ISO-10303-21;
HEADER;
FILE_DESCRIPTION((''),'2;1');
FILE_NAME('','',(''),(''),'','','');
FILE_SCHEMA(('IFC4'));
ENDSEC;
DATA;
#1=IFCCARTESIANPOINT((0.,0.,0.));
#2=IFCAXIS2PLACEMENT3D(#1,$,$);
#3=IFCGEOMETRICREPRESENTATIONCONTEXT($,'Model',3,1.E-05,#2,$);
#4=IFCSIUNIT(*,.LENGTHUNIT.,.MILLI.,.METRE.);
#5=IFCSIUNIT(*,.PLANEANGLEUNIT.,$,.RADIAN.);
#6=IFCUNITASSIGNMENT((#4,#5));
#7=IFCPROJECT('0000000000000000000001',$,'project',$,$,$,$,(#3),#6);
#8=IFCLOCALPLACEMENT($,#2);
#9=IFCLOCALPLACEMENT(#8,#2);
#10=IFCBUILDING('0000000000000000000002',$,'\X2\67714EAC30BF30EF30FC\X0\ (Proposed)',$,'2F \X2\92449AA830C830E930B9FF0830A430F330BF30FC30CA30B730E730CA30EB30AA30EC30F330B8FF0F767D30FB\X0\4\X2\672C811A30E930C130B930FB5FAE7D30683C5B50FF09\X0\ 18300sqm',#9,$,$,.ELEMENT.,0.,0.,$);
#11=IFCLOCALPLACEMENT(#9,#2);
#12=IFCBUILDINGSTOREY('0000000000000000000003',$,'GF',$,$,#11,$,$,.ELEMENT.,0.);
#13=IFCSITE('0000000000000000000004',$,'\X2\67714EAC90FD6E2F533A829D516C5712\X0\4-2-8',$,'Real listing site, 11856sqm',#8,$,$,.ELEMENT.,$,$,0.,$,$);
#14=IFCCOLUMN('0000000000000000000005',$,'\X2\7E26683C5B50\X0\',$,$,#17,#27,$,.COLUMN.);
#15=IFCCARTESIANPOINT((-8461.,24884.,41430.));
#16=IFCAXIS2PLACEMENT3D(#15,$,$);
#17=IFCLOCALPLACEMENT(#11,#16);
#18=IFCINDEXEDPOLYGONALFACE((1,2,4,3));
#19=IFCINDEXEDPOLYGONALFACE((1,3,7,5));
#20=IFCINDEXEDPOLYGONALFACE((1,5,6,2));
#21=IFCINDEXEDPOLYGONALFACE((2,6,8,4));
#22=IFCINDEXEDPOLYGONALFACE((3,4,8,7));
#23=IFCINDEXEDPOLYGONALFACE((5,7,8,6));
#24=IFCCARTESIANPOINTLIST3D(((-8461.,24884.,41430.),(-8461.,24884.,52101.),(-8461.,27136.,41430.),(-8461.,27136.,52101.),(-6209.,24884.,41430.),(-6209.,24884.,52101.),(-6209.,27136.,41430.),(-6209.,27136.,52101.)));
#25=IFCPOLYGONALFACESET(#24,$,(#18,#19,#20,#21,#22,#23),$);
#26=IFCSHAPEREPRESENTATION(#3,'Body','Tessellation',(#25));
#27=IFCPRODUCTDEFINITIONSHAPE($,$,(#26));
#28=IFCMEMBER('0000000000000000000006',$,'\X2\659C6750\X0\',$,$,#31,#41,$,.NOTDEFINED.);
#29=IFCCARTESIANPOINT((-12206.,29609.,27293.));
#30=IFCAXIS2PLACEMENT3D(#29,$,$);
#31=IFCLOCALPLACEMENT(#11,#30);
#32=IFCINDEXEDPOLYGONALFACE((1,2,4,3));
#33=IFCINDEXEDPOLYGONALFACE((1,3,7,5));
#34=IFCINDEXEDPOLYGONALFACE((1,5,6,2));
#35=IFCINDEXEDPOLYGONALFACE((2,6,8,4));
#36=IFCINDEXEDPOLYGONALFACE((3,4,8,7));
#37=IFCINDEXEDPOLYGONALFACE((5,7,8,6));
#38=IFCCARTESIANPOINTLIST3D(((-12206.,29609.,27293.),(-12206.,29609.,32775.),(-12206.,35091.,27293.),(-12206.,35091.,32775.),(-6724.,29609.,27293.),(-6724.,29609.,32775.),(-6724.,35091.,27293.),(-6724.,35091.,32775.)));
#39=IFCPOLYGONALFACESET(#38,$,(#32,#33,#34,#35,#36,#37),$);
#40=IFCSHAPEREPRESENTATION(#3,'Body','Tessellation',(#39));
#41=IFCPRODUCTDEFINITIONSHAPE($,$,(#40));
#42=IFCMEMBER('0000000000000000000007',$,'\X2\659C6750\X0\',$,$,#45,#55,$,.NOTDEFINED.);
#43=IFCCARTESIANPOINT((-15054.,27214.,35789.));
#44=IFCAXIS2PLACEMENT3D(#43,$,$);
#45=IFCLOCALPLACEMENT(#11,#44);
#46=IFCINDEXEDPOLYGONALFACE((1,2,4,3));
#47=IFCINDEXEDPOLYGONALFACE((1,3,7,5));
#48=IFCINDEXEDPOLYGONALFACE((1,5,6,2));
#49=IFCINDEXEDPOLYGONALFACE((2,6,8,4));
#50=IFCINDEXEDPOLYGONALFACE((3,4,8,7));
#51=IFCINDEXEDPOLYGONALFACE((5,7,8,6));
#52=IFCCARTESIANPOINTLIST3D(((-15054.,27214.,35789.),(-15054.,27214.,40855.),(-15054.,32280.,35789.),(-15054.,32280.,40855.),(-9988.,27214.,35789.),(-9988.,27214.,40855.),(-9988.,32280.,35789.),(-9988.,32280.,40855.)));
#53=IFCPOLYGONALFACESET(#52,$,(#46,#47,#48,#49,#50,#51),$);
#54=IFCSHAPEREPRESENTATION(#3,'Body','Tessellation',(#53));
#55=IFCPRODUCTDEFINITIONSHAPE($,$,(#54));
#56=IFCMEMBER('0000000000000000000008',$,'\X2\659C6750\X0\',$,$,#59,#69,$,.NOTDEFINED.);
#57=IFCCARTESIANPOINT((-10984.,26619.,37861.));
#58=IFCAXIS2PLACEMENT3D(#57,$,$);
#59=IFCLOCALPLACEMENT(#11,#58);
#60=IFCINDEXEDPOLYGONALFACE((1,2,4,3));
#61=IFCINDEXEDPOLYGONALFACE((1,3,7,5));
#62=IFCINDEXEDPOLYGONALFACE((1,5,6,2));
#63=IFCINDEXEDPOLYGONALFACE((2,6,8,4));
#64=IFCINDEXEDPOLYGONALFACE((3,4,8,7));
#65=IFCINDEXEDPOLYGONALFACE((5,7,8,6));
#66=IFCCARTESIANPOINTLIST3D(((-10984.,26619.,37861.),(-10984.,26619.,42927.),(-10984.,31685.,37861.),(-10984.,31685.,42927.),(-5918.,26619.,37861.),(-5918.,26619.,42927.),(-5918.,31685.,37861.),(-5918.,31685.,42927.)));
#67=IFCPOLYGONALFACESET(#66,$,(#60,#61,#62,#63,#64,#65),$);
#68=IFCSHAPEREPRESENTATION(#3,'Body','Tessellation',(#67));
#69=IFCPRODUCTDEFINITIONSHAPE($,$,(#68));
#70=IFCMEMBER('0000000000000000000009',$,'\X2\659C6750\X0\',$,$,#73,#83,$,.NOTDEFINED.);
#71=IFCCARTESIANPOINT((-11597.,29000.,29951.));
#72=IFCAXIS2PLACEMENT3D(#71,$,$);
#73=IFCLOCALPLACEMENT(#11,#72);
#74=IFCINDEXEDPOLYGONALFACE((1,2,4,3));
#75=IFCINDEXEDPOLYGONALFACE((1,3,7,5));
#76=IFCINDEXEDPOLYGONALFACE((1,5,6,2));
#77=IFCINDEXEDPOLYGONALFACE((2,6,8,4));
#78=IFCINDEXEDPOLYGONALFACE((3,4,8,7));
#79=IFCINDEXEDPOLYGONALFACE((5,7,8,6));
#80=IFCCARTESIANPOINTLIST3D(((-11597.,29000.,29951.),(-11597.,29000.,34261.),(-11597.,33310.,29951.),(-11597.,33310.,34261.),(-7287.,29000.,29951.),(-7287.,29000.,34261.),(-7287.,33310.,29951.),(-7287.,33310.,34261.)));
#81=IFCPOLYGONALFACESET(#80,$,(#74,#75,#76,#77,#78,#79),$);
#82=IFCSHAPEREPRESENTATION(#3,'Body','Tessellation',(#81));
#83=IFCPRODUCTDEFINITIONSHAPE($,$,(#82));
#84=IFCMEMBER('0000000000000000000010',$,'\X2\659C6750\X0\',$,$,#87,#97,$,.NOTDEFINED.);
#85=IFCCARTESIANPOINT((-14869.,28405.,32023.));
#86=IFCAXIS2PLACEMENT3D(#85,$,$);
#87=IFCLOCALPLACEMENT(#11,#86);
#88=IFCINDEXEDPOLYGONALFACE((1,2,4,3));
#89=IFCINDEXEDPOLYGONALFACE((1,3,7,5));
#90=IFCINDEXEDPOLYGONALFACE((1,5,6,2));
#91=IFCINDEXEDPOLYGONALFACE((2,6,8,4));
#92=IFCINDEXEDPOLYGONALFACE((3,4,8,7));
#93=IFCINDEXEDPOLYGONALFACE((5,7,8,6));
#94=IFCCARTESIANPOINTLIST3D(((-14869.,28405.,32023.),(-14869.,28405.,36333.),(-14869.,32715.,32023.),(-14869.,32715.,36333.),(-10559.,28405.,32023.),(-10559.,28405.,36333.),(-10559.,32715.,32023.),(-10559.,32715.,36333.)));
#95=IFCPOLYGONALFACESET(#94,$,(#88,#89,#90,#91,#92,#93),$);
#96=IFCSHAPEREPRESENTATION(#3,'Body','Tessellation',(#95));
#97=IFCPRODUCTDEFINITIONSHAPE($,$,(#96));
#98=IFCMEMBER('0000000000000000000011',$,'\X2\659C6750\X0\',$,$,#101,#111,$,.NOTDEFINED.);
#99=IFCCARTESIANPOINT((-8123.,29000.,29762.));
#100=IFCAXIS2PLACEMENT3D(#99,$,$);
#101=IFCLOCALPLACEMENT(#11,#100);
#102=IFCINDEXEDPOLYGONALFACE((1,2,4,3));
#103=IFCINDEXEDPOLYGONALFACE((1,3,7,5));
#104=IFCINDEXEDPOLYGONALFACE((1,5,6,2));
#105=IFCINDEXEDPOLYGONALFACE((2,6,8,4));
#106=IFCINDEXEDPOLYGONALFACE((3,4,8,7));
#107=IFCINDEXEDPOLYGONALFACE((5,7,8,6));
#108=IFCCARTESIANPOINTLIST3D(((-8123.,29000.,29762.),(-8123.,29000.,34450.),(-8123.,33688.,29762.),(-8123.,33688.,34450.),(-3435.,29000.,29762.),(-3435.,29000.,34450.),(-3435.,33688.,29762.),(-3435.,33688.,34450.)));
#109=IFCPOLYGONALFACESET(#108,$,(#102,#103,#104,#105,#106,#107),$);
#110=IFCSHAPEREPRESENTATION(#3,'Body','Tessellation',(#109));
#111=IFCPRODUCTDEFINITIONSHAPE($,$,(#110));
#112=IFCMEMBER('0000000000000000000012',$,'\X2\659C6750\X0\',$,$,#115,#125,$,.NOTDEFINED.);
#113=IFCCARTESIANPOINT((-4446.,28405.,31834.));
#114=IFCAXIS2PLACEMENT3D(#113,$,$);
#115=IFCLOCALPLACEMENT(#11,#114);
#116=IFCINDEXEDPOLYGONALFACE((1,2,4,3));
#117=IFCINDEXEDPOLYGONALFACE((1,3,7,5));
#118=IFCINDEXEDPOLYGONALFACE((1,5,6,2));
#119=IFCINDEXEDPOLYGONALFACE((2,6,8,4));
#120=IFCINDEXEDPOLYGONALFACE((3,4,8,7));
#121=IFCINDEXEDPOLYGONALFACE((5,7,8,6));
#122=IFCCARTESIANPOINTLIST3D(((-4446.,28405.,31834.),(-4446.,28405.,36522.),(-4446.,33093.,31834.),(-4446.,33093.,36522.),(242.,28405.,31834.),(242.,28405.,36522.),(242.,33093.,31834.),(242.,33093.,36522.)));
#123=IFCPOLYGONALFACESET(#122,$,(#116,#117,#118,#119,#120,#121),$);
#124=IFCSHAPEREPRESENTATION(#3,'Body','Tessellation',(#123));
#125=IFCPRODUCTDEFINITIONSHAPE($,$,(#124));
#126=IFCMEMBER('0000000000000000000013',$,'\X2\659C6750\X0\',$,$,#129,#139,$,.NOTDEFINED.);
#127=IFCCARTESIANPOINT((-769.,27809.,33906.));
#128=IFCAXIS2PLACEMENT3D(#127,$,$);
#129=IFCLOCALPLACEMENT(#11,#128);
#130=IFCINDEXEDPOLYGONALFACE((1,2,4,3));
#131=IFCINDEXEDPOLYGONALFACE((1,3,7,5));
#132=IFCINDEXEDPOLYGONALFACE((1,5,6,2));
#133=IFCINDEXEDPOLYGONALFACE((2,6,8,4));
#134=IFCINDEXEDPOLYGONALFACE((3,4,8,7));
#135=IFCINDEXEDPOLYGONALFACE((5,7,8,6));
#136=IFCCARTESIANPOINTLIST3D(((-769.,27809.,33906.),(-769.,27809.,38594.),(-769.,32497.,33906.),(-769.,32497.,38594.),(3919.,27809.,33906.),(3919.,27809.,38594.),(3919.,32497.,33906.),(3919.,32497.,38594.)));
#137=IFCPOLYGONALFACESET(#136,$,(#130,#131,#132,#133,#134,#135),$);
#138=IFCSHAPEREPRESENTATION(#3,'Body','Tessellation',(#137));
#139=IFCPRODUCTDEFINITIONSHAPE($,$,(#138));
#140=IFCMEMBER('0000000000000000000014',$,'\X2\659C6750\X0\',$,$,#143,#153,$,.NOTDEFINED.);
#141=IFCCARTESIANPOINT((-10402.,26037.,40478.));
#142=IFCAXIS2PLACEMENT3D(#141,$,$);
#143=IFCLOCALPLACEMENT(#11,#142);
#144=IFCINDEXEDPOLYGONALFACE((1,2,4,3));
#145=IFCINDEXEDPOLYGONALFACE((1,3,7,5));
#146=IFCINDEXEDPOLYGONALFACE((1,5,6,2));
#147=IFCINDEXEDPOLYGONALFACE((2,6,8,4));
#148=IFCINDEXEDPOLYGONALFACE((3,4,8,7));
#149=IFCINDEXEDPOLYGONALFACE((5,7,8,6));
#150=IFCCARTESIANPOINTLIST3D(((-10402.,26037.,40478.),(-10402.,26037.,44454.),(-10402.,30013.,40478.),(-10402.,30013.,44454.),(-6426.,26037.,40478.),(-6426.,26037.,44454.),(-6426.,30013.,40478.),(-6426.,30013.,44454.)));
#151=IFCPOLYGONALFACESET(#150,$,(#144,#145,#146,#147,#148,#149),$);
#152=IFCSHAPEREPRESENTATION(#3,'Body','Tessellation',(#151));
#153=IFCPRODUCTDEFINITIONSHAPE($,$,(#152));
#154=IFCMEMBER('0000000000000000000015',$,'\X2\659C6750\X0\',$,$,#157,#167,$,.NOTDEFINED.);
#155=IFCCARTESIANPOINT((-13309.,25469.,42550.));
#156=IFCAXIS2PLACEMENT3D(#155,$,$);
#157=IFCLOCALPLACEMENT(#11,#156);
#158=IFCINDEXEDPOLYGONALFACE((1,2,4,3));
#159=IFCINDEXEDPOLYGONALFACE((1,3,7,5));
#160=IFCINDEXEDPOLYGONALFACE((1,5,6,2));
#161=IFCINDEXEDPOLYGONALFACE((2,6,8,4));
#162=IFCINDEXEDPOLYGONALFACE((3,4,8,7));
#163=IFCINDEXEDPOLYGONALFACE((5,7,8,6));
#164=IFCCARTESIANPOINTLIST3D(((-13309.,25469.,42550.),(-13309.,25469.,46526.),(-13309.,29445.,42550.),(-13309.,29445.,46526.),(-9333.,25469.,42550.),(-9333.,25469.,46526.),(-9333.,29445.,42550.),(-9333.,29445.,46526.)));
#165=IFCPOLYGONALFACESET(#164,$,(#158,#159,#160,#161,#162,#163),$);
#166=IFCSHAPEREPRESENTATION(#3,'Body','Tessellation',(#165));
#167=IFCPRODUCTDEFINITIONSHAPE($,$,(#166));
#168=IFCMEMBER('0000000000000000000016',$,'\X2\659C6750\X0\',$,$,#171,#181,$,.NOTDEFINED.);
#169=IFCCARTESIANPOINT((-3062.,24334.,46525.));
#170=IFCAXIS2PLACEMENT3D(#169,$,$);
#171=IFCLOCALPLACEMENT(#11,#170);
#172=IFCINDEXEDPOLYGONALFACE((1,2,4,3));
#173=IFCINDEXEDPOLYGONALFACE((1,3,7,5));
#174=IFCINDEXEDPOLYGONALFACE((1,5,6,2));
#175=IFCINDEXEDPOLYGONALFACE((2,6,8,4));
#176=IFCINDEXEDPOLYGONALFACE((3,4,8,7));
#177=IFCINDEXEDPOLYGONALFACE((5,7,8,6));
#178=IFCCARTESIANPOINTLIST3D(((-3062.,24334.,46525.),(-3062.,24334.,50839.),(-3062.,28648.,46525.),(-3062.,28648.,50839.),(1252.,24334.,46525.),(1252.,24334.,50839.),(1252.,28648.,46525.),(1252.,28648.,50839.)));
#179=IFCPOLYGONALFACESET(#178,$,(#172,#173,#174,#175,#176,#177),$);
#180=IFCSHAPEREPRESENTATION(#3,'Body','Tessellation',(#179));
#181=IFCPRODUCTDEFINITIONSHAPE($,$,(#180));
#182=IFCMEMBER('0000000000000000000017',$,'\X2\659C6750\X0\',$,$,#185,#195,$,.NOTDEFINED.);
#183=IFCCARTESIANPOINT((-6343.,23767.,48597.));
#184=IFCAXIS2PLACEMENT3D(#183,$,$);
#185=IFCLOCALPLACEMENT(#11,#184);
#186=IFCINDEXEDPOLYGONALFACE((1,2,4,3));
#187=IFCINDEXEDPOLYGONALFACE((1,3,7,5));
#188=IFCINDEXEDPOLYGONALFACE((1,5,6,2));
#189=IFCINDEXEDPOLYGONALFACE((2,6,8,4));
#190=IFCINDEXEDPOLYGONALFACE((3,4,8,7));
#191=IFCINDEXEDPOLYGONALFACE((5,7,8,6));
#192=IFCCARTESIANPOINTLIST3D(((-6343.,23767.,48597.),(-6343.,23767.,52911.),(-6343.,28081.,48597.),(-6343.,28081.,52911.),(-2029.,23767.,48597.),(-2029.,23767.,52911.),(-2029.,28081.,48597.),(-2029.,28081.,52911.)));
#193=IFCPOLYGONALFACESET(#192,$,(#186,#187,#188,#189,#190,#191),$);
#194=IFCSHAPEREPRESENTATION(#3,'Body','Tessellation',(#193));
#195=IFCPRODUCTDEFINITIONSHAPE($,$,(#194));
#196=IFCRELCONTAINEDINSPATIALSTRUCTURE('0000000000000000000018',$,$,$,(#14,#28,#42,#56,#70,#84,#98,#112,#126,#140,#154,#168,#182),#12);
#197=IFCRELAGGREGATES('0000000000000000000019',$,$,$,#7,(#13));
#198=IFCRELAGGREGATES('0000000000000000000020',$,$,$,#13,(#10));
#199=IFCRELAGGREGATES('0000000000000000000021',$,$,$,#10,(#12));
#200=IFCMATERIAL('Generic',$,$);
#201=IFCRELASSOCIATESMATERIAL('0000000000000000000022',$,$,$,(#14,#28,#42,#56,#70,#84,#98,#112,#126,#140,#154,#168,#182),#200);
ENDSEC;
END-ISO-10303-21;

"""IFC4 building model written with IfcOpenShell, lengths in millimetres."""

from ifc_helpers import new_model, si_unit, frame, frame_2d, origin, place, context, project, spatial, rectangle, extrude, material, element, save


model = new_model("IFC4")

# Units and contexts
model_context = context("Model", 3, precision=1e-05, world=origin())
ifc_project = project(units=[si_unit("LENGTHUNIT", "METRE", prefix="MILLI"), si_unit("PLANEANGLEUNIT", "RADIAN")], contexts=[model_context])

# Site, building, storey
site_placement = place(None, origin())
site = spatial("IfcSite", under=ifc_project, at=site_placement, Name="東京都港区芝公園4-2-8", ObjectType="Real listing site, 11856sqm", CompositionType="ELEMENT", RefElevation=0.0)
building_placement = place(site_placement, origin())
building = spatial("IfcBuilding", under=site, at=building_placement, Name="東京タワー (Proposed)", ObjectType="2F 鉄骨トラス（インターナショナルオレンジ／白・4本脚ラチス・微細格子） 18300sqm", CompositionType="ELEMENT", ElevationOfRefHeight=0.0, ElevationOfTerrain=0.0)
storey_placement = place(building_placement, origin())
storey = spatial("IfcBuildingStorey", under=building, at=storey_placement, Name="GF", CompositionType="ELEMENT", Elevation=0.0)

# Column
ifc_material = material(Name="Generic")
column_1_placement = place(storey_placement, frame((-8461.0, 24884.0, 41430.0)))
element("IfcColumn", 1, at=column_1_placement, inside=storey, material=ifc_material, Name="縦格子", PredefinedType="COLUMN", context=model_context, shape_type="SweptSolid", body=[
    extrude(rectangle(XDim=2252.0, YDim=2252.0, at=frame_2d((1126.0, 1126.0))), frame((-8461.0, 24884.0, 41430.0)), (0.0, 0.0, 1.0), 10671.0),
])

# Members
member_1_placement = place(storey_placement, frame((-12206.0, 29609.0, 27293.0)))
element("IfcMember", 2, at=member_1_placement, inside=storey, material=ifc_material, Name="斜材", PredefinedType="NOTDEFINED", context=model_context, shape_type="SweptSolid", body=[
    extrude(rectangle(XDim=5482.0, YDim=5482.0, at=frame_2d((2741.0, 2741.0))), frame((-12206.0, 29609.0, 27293.0)), (0.0, 0.0, 1.0), 5482.0),
])
member_2_placement = place(storey_placement, frame((-15054.0, 27214.0, 35789.0)))
element("IfcMember", 3, at=member_2_placement, inside=storey, material=ifc_material, Name="斜材", PredefinedType="NOTDEFINED", context=model_context, shape_type="SweptSolid", body=[
    extrude(rectangle(XDim=5066.0, YDim=5066.0, at=frame_2d((2533.0, 2533.0))), frame((-15054.0, 27214.0, 35789.0)), (0.0, 0.0, 1.0), 5066.0),
])
member_3_placement = place(storey_placement, frame((-10984.0, 26619.0, 37861.0)))
element("IfcMember", 4, at=member_3_placement, inside=storey, material=ifc_material, Name="斜材", PredefinedType="NOTDEFINED", context=model_context, shape_type="SweptSolid", body=[
    extrude(rectangle(XDim=5066.0, YDim=5066.0, at=frame_2d((2533.0, 2533.0))), frame((-10984.0, 26619.0, 37861.0)), (0.0, 0.0, 1.0), 5066.0),
])
member_4_placement = place(storey_placement, frame((-11597.0, 29000.0, 29951.0)))
element("IfcMember", 5, at=member_4_placement, inside=storey, material=ifc_material, Name="斜材", PredefinedType="NOTDEFINED", context=model_context, shape_type="SweptSolid", body=[
    extrude(rectangle(XDim=4310.0, YDim=4310.0, at=frame_2d((2155.0, 2155.0))), frame((-11597.0, 29000.0, 29951.0)), (0.0, 0.0, 1.0), 4310.0),
])
member_5_placement = place(storey_placement, frame((-14869.0, 28405.0, 32023.0)))
element("IfcMember", 6, at=member_5_placement, inside=storey, material=ifc_material, Name="斜材", PredefinedType="NOTDEFINED", context=model_context, shape_type="SweptSolid", body=[
    extrude(rectangle(XDim=4310.0, YDim=4310.0, at=frame_2d((2155.0, 2155.0))), frame((-14869.0, 28405.0, 32023.0)), (0.0, 0.0, 1.0), 4310.0),
])
member_6_placement = place(storey_placement, frame((-8123.0, 29000.0, 29762.0)))
element("IfcMember", 7, at=member_6_placement, inside=storey, material=ifc_material, Name="斜材", PredefinedType="NOTDEFINED", context=model_context, shape_type="SweptSolid", body=[
    extrude(rectangle(XDim=4688.0, YDim=4688.0, at=frame_2d((2344.0, 2344.0))), frame((-8123.0, 29000.0, 29762.0)), (0.0, 0.0, 1.0), 4688.0),
])
member_7_placement = place(storey_placement, frame((-4446.0, 28405.0, 31834.0)))
element("IfcMember", 8, at=member_7_placement, inside=storey, material=ifc_material, Name="斜材", PredefinedType="NOTDEFINED", context=model_context, shape_type="SweptSolid", body=[
    extrude(rectangle(XDim=4688.0, YDim=4688.0, at=frame_2d((2344.0, 2344.0))), frame((-4446.0, 28405.0, 31834.0)), (0.0, 0.0, 1.0), 4688.0),
])
member_8_placement = place(storey_placement, frame((-769.0, 27809.0, 33906.0)))
element("IfcMember", 9, at=member_8_placement, inside=storey, material=ifc_material, Name="斜材", PredefinedType="NOTDEFINED", context=model_context, shape_type="SweptSolid", body=[
    extrude(rectangle(XDim=4688.0, YDim=4688.0, at=frame_2d((2344.0, 2344.0))), frame((-769.0, 27809.0, 33906.0)), (0.0, 0.0, 1.0), 4688.0),
])
member_9_placement = place(storey_placement, frame((-10402.0, 26037.0, 40478.0)))
element("IfcMember", 10, at=member_9_placement, inside=storey, material=ifc_material, Name="斜材", PredefinedType="NOTDEFINED", context=model_context, shape_type="SweptSolid", body=[
    extrude(rectangle(XDim=3976.0, YDim=3976.0, at=frame_2d((1988.0, 1988.0))), frame((-10402.0, 26037.0, 40478.0)), (0.0, 0.0, 1.0), 3976.0),
])
member_10_placement = place(storey_placement, frame((-13309.0, 25469.0, 42550.0)))
element("IfcMember", 11, at=member_10_placement, inside=storey, material=ifc_material, Name="斜材", PredefinedType="NOTDEFINED", context=model_context, shape_type="SweptSolid", body=[
    extrude(rectangle(XDim=3976.0, YDim=3976.0, at=frame_2d((1988.0, 1988.0))), frame((-13309.0, 25469.0, 42550.0)), (0.0, 0.0, 1.0), 3976.0),
])
member_11_placement = place(storey_placement, frame((-3062.0, 24334.0, 46525.0)))
element("IfcMember", 12, at=member_11_placement, inside=storey, material=ifc_material, Name="斜材", PredefinedType="NOTDEFINED", context=model_context, shape_type="SweptSolid", body=[
    extrude(rectangle(XDim=4314.0, YDim=4314.0, at=frame_2d((2157.0, 2157.0))), frame((-3062.0, 24334.0, 46525.0)), (0.0, 0.0, 1.0), 4314.0),
])
member_12_placement = place(storey_placement, frame((-6343.0, 23767.0, 48597.0)))
element("IfcMember", 13, at=member_12_placement, inside=storey, material=ifc_material, Name="斜材", PredefinedType="NOTDEFINED", context=model_context, shape_type="SweptSolid", body=[
    extrude(rectangle(XDim=4314.0, YDim=4314.0, at=frame_2d((2157.0, 2157.0))), frame((-6343.0, 23767.0, 48597.0)), (0.0, 0.0, 1.0), 4314.0),
])

save(model, "model.ifc")
